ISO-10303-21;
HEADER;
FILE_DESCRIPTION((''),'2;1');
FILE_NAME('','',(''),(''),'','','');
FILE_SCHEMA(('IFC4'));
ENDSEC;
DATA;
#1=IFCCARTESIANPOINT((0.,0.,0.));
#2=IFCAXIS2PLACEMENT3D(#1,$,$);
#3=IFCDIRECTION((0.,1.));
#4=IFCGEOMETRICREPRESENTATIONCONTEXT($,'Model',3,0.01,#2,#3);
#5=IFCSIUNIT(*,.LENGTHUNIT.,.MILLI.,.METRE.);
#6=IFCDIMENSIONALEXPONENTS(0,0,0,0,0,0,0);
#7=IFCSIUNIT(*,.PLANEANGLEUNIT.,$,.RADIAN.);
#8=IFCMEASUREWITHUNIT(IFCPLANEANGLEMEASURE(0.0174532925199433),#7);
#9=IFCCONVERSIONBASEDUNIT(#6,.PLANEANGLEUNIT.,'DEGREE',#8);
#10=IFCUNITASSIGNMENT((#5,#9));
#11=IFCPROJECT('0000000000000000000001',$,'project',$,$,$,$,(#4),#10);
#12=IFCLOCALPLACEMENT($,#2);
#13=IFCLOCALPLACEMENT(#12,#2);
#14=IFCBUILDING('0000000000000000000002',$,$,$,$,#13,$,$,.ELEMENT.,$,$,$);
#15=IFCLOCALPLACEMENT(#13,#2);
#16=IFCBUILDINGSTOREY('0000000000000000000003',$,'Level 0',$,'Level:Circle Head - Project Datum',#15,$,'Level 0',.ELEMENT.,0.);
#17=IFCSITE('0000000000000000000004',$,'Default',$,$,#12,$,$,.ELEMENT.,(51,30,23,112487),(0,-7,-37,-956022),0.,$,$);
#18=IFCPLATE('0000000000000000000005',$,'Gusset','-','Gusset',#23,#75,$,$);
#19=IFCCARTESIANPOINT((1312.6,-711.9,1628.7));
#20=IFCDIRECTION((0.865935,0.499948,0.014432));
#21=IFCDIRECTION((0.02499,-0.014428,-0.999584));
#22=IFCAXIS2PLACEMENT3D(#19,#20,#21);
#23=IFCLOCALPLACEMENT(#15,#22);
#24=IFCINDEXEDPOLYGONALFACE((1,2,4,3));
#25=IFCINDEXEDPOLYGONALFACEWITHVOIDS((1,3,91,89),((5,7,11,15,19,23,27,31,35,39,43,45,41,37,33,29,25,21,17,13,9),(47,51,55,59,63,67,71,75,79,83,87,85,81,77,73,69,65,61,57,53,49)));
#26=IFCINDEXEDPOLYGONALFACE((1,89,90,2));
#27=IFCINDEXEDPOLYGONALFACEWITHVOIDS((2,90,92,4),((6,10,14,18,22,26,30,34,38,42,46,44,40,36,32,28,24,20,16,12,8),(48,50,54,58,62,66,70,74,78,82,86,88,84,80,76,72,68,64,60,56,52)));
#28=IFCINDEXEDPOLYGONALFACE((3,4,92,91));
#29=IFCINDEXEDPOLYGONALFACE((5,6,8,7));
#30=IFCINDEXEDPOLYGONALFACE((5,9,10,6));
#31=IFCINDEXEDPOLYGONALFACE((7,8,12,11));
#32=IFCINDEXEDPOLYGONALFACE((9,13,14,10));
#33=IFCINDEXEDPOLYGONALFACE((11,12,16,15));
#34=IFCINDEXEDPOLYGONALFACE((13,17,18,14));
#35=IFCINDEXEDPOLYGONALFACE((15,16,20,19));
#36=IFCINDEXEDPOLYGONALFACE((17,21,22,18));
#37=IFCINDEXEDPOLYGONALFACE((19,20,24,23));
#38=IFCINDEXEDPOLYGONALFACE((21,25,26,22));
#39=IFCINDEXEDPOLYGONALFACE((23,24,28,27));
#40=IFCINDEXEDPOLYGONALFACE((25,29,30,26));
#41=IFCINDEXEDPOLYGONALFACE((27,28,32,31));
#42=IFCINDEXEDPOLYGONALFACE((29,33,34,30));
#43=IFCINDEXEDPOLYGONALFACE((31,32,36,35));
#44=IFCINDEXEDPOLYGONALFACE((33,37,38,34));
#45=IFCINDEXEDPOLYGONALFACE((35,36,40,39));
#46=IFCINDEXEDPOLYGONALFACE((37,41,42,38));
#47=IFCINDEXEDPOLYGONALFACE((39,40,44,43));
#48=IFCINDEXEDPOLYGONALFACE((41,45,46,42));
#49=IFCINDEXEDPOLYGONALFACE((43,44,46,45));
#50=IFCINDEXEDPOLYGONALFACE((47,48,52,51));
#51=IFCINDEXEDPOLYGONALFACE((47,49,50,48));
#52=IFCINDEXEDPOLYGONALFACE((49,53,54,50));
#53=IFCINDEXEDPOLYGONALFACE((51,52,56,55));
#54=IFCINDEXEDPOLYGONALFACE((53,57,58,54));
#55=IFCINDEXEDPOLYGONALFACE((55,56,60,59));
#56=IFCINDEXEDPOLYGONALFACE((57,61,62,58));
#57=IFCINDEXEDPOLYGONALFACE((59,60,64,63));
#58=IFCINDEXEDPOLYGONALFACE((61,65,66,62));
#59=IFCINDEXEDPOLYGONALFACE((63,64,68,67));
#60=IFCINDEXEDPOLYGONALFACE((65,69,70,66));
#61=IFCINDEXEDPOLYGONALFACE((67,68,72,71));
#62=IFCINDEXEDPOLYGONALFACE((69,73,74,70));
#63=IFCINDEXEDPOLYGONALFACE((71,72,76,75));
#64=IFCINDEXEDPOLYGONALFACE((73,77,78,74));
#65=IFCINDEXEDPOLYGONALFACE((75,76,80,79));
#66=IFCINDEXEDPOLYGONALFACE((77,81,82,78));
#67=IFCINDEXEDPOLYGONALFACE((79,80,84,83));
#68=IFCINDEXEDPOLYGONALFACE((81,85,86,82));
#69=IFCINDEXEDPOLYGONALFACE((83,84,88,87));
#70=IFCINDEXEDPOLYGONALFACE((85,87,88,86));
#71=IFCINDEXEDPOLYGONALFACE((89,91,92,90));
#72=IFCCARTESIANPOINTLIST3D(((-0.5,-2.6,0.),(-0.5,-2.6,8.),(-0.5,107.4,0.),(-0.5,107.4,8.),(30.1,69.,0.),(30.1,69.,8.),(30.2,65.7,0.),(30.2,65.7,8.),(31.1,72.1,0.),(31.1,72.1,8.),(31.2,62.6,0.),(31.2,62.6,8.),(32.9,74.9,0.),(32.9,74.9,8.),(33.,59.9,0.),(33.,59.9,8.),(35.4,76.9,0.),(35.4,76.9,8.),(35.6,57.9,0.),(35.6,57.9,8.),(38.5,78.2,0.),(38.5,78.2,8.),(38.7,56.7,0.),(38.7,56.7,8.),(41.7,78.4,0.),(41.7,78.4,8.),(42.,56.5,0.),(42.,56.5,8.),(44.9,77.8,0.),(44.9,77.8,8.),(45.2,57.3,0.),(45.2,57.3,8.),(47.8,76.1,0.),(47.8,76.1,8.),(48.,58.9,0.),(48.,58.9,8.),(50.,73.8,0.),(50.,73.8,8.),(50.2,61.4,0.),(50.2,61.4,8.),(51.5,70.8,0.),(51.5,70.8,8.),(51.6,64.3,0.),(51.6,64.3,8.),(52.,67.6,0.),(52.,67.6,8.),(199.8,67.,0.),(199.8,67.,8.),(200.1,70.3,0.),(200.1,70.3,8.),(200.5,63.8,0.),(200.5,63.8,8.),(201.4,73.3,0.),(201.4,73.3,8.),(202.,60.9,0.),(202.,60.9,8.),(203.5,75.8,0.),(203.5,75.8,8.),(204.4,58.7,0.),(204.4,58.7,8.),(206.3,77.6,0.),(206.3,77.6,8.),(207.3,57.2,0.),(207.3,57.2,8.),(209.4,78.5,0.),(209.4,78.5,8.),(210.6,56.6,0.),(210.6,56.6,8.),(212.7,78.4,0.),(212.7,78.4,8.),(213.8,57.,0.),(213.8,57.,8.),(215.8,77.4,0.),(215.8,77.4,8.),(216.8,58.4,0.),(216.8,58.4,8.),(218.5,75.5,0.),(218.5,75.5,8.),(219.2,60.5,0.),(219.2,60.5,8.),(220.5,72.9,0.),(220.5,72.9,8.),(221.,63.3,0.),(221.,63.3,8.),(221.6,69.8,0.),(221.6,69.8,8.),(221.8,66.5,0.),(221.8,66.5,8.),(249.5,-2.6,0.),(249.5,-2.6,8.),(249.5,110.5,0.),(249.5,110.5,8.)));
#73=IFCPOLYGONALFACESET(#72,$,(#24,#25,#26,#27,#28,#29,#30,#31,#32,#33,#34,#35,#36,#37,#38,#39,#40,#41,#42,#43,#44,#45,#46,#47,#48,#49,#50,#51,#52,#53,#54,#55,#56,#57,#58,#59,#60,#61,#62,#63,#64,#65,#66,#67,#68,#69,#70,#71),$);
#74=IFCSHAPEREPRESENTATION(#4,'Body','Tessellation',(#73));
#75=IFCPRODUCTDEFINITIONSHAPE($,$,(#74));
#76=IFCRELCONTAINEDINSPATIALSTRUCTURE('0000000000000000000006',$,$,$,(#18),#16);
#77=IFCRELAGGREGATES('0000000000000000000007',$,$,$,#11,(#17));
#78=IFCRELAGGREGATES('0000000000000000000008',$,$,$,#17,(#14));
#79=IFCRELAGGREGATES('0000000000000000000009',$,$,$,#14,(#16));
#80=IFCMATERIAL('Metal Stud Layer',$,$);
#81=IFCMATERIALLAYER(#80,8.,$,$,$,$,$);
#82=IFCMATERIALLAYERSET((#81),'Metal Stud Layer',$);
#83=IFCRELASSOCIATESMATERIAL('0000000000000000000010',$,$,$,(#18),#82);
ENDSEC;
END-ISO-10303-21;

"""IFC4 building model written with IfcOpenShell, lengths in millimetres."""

from ifc_helpers import new_model, entity, si_unit, converted_unit, direction, frame, origin, origin_with_axes, origin_2d_with_axis, place, context, project, spatial, polyline, circle, outline, extrude, material, layer, layer_set, element, save


model = new_model("IFC4")

# Units and contexts
model_context = context("Model", 3, precision=0.01, world=origin(), true_north=direction((0.0, 1.0)))
ifc_project = project(units=[si_unit("LENGTHUNIT", "METRE", prefix="MILLI"), converted_unit("PLANEANGLEUNIT", "DEGREE", entity("IfcPlaneAngleMeasure", 0.0174532925199433), si_unit("PLANEANGLEUNIT", "RADIAN"), dimensions=[0, 0, 0, 0, 0, 0, 0])], contexts=[model_context])

# Site, building, storey
site_placement = place(None, origin())
site = spatial("IfcSite", under=ifc_project, at=site_placement, Name="Default", CompositionType="ELEMENT", RefLatitude=(51, 30, 23, 112487), RefLongitude=(0, -7, -37, -956022), RefElevation=0.0)
building_placement = place(site_placement, origin())
building = spatial("IfcBuilding", under=site, at=building_placement, CompositionType="ELEMENT")
storey_placement = place(building_placement, origin())
storey = spatial("IfcBuildingStorey", under=building, at=storey_placement, Name="Level 0", ObjectType="Level:Circle Head - Project Datum", LongName="Level 0", CompositionType="ELEMENT", Elevation=0.0)

# Plate, openings
ifc_material = material(Name="Metal Stud Layer")
ifc_layer_1 = layer(ifc_material, 8.0)
ifc_layer_set_1 = layer_set([ifc_layer_1], Name="Metal Stud Layer")
plate_1_placement = place(storey_placement, frame((1312.6, -711.9, 1628.7), z_axis=(0.865935, 0.499948, 0.014432), x_axis=(0.02499, -0.014428, -0.999584)))
plate_1 = element("IfcPlate", 1, at=plate_1_placement, inside=storey, material=ifc_layer_set_1, Name="Gusset", Description="-", ObjectType="Gusset", context=model_context, shape_type="SweptSolid", body=[
    extrude(outline(polyline([(-0.5, -2.6), (249.5, -2.6), (249.5, 110.5), (-0.5, 107.4), (-0.5, -2.6)])), origin_with_axes(), (0.0, 0.0, 1.0), 8.0),
])
opening_1_placement = place(plate_1_placement, frame((41.0, 67.5, 8.5), z_axis=(0.0, 0.0, -1.0), x_axis=(-0.509338, 0.860567, 0.0)))
element("IfcOpeningElement", 2, at=opening_1_placement, cuts=plate_1, ObjectType="Opening", context=model_context, shape_type="SweptSolid", body=[
    extrude(circle(Radius=11.0, at=origin_2d_with_axis()), origin(), (0.0, 0.0, 1.0), 9.0),
])
opening_2_placement = place(plate_1_placement, frame((210.8, 67.6, 8.5), z_axis=(0.0, 0.0, -1.0), x_axis=(0.454822, 0.890582, 0.0)))
element("IfcOpeningElement", 3, at=opening_2_placement, cuts=plate_1, ObjectType="Opening", context=model_context, shape_type="SweptSolid", body=[
    extrude(circle(Radius=11.0, at=origin_2d_with_axis()), origin(), (0.0, 0.0, 1.0), 9.0),
])

save(model, "model.ifc")
